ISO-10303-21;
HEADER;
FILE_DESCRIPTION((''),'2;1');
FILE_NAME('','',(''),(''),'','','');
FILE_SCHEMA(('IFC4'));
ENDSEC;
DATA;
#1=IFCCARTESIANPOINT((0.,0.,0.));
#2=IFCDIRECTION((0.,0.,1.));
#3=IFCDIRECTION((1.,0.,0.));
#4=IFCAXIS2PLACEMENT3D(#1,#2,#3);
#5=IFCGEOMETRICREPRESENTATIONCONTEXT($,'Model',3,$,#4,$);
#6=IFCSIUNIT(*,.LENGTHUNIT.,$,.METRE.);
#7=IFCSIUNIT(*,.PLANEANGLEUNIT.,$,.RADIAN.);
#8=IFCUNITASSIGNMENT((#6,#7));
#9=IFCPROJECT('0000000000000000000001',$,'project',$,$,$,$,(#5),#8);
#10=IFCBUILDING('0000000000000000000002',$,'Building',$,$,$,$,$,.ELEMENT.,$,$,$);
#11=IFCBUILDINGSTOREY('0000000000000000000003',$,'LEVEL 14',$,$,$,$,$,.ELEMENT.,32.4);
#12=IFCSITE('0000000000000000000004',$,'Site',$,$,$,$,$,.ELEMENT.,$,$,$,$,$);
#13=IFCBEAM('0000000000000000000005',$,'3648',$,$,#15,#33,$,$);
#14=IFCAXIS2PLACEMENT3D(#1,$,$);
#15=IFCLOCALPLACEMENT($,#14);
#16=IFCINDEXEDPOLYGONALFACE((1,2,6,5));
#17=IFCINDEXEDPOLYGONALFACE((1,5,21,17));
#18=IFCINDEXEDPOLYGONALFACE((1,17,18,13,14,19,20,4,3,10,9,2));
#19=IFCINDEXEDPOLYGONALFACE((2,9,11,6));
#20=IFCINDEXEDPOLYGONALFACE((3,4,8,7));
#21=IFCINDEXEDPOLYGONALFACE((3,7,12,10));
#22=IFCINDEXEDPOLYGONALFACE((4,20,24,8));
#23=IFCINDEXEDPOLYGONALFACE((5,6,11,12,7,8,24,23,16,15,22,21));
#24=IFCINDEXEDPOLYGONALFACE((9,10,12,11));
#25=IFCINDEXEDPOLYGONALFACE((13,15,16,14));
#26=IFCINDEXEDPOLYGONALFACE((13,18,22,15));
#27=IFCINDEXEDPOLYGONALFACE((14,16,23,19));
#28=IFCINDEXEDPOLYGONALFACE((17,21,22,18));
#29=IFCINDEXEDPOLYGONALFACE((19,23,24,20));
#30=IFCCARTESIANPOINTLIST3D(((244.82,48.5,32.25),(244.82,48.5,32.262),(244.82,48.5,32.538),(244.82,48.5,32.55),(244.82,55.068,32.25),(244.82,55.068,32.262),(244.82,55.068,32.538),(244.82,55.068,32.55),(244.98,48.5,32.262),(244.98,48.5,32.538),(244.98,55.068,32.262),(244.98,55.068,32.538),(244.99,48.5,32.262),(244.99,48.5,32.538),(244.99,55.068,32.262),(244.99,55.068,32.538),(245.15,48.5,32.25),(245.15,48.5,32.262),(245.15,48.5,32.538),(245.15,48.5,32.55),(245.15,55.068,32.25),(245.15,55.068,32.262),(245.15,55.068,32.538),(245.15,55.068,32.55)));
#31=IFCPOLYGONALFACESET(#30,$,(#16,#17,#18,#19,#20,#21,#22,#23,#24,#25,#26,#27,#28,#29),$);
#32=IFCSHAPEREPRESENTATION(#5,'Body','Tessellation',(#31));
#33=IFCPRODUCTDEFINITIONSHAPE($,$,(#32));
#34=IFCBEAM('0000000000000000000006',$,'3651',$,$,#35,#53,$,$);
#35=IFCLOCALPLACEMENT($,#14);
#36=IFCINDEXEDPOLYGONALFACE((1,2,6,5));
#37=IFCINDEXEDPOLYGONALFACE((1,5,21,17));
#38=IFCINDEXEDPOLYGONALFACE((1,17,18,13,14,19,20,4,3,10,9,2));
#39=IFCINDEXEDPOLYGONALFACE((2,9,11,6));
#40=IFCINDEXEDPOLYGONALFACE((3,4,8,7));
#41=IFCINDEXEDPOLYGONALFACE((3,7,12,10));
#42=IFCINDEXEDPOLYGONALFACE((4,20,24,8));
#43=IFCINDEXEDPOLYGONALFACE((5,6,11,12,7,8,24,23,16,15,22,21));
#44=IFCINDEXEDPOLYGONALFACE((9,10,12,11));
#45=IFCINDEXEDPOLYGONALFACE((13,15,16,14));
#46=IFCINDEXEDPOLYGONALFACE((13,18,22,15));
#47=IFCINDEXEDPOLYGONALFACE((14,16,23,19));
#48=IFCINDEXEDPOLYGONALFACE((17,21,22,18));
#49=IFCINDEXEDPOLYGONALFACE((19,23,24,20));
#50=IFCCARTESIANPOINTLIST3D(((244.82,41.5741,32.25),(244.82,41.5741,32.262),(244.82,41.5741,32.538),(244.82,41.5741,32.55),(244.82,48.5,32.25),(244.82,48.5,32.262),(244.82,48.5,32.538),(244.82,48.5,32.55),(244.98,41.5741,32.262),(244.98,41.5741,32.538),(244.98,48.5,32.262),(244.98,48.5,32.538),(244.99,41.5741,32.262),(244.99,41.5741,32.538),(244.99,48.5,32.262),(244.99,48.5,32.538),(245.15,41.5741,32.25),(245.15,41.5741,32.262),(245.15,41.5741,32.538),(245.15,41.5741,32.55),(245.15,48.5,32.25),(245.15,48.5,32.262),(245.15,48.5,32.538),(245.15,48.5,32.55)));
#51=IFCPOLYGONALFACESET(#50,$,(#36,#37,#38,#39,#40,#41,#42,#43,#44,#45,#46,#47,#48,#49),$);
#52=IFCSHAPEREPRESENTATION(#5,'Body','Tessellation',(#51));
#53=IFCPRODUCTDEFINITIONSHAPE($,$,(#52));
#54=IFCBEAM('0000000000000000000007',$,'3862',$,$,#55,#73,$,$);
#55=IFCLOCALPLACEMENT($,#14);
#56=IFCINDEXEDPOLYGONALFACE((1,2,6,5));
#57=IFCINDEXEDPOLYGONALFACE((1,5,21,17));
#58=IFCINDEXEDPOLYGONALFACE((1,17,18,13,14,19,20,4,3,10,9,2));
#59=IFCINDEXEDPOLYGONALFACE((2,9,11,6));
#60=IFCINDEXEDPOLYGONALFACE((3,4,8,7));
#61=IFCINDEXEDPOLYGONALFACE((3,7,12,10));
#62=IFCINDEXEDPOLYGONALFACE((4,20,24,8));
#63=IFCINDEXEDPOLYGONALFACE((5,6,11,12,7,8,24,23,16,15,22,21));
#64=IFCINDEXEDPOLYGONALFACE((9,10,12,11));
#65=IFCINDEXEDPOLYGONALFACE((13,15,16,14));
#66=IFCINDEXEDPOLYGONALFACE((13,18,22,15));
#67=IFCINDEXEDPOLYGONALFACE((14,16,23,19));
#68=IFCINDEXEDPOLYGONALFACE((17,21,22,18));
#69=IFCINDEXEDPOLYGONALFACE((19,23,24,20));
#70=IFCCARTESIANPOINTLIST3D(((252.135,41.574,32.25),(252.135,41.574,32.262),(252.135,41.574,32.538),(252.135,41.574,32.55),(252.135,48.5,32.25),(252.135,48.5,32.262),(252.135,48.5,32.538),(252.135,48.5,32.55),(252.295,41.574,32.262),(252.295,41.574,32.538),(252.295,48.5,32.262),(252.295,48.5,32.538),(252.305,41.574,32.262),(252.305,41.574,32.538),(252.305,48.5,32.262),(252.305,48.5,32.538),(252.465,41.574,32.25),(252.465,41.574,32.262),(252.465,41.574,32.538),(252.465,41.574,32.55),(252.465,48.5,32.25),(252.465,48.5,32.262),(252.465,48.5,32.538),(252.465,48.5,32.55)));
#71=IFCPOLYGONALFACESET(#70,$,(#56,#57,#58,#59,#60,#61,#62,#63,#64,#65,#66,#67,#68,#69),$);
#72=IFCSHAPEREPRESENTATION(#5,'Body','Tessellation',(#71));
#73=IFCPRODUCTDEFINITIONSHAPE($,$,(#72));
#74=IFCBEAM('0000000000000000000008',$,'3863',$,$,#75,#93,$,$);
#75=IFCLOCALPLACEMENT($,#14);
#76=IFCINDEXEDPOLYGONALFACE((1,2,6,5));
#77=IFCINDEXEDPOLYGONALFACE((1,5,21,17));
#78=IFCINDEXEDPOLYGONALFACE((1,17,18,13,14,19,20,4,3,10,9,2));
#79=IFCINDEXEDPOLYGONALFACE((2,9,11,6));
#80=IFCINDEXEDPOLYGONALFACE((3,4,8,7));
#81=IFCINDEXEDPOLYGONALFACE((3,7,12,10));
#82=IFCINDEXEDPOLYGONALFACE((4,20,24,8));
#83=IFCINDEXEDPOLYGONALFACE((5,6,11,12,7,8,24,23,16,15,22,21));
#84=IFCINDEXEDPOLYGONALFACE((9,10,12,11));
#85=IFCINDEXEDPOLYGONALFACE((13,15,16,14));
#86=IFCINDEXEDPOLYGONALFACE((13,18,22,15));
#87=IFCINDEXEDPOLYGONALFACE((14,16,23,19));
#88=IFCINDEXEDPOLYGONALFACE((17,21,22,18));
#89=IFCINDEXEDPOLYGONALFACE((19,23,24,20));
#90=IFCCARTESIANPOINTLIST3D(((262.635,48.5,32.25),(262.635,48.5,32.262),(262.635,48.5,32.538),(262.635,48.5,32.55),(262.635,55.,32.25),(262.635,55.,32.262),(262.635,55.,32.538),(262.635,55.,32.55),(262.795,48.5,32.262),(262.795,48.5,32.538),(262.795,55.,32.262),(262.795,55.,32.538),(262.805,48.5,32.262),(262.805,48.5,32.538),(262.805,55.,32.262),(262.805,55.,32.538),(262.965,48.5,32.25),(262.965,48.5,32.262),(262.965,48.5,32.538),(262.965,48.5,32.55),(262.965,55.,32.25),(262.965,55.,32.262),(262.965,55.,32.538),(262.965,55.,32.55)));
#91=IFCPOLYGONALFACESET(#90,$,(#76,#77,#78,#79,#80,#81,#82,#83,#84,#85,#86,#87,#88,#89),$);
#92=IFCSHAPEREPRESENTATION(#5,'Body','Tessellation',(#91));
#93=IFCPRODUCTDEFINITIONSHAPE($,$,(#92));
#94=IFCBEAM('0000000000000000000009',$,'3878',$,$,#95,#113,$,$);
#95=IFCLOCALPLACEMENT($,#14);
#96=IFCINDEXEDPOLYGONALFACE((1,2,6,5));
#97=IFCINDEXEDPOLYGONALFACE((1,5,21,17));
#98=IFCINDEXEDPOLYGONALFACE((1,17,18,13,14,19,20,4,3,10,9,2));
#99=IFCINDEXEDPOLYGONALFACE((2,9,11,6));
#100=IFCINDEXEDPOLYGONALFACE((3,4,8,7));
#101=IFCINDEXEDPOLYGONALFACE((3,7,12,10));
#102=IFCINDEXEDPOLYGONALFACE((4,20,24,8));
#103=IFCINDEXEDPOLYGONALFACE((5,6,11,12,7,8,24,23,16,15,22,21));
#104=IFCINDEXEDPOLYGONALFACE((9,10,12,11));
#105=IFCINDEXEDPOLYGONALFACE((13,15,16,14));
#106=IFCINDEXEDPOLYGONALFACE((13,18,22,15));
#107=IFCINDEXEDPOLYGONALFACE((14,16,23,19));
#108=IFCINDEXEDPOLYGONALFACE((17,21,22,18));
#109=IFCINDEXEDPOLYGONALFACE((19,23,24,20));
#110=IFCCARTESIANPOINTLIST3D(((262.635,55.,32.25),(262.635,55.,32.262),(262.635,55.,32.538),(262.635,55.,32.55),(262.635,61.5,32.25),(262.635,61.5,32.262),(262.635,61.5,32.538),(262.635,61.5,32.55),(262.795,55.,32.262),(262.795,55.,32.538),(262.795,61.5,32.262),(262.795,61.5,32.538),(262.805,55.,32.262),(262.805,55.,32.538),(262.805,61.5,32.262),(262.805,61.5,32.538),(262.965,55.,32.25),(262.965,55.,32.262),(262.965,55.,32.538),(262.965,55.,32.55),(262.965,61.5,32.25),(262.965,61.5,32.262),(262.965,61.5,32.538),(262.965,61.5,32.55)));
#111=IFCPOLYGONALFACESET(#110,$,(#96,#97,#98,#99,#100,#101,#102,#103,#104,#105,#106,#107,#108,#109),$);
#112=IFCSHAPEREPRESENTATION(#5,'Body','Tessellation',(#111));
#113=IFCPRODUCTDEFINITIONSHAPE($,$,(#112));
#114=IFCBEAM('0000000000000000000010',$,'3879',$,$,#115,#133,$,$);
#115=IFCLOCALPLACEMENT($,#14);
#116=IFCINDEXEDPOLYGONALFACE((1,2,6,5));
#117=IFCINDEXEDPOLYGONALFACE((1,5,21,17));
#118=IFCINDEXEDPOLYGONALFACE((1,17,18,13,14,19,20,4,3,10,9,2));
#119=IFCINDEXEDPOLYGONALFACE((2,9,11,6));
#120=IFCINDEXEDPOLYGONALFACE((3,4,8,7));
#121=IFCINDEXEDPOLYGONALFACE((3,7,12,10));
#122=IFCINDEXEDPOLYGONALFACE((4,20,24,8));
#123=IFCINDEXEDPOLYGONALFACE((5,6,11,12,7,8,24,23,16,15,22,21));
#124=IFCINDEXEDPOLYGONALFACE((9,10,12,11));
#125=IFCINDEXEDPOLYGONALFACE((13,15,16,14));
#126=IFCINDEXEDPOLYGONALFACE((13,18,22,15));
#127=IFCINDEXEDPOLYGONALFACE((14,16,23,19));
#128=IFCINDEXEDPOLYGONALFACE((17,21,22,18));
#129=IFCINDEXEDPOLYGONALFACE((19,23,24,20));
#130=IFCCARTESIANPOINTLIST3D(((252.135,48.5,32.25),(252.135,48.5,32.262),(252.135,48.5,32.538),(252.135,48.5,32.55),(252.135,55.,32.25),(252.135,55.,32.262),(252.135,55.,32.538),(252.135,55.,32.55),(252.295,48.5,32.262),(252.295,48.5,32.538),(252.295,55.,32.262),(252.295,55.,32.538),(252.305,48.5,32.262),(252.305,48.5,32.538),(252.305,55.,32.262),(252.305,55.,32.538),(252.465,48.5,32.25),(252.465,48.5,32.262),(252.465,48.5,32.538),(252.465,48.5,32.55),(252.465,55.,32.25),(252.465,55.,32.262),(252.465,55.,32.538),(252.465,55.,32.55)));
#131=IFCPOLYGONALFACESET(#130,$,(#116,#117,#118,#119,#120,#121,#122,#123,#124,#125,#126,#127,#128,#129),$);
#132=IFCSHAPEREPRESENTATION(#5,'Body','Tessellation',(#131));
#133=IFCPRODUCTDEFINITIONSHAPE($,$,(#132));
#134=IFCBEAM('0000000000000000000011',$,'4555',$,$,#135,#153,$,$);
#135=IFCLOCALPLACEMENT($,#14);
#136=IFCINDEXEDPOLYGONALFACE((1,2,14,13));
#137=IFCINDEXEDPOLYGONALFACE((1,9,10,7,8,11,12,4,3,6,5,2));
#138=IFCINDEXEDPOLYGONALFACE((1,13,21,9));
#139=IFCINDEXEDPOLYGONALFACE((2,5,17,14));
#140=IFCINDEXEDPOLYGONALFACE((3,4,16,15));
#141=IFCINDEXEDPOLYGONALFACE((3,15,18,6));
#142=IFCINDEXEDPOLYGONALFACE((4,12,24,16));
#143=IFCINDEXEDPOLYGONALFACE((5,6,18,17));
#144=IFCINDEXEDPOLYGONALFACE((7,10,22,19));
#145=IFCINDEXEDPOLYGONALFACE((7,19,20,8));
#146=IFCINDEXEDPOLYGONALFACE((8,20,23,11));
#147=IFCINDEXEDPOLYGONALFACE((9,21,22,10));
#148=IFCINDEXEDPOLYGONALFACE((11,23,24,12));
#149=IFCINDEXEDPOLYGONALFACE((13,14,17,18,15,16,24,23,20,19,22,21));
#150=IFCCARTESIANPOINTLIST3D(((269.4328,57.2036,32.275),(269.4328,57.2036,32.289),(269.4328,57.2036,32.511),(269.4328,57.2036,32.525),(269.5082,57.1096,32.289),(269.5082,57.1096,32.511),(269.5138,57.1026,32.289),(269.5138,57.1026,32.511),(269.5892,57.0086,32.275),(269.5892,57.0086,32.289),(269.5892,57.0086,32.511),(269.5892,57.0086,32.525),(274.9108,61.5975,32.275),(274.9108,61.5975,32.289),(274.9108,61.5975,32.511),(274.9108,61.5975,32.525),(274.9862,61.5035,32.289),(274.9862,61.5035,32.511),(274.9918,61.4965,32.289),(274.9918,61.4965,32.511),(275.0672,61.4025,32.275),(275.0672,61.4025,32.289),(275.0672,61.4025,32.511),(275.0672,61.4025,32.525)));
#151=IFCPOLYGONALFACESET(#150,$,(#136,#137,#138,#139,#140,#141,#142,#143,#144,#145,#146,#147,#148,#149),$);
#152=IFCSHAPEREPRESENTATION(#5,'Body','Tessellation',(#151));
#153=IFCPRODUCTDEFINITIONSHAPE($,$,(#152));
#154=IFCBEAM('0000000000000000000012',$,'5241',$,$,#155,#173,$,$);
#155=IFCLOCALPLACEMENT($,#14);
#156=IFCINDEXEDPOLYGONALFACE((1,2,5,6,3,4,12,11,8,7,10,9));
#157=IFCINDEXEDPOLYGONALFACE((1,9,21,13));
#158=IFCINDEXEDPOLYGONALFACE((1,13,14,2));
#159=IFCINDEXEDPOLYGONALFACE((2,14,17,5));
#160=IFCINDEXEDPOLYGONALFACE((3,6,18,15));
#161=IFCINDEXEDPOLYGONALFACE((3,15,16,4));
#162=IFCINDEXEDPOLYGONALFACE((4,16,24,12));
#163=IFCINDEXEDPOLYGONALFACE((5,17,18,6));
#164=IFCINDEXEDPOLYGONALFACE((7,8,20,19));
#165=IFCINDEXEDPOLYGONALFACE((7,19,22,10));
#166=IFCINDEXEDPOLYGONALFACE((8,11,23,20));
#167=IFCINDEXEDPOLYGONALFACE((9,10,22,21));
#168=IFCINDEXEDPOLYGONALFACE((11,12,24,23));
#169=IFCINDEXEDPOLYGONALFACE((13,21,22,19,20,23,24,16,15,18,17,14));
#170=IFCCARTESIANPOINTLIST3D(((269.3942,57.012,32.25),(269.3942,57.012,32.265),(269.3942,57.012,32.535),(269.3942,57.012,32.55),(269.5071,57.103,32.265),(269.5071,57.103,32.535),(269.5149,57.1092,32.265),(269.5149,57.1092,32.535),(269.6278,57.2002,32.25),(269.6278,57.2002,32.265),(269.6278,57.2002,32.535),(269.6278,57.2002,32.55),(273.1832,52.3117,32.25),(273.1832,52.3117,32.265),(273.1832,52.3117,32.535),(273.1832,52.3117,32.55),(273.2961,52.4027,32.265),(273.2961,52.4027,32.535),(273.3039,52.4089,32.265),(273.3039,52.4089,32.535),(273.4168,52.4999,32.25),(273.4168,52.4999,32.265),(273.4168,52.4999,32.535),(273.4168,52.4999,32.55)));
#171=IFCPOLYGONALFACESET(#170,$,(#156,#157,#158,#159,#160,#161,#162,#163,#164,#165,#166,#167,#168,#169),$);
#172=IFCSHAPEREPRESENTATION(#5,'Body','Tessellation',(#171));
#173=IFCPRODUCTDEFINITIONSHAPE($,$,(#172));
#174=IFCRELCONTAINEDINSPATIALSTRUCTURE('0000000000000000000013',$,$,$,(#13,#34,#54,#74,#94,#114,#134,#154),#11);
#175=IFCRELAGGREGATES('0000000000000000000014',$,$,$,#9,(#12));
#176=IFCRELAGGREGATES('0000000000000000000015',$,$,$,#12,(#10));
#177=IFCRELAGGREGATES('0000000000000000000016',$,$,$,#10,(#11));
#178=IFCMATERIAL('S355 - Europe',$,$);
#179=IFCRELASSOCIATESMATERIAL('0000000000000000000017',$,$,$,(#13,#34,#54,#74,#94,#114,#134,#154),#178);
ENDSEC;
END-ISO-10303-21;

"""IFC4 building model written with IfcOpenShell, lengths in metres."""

from ifc_helpers import new_model, si_unit, frame, origin_with_axes, origin_2d_with_axis, place, context, project, spatial, i_section, extrude, material, material_profile, profile_set, profile_usage, element, save


model = new_model("IFC4")

# Units and contexts
model_context = context("Model", 3, world=origin_with_axes())
ifc_project = project(units=[si_unit("LENGTHUNIT", "METRE"), si_unit("PLANEANGLEUNIT", "RADIAN")], contexts=[model_context])

# Site, building, storey
site = spatial("IfcSite", under=ifc_project, Name="Site", CompositionType="ELEMENT")
building = spatial("IfcBuilding", under=site, Name="Building", CompositionType="ELEMENT")
storey = spatial("IfcBuildingStorey", under=building, Name="LEVEL 14", CompositionType="ELEMENT", Elevation=32.4)

# Shared definitions
ifc_material = material(Name="S355 - Europe")

# Beams
ifc_material_profile_1 = material_profile(ifc_material, i_section(OverallWidth=0.33, OverallDepth=0.3, WebThickness=0.01, FlangeThickness=0.012, at=origin_2d_with_axis()))
ifc_profile_set_1 = profile_set([ifc_material_profile_1])
ifc_profile_usage_1 = profile_usage(ifc_profile_set_1, cardinal=10)
beam_1_placement = place(None, frame((244.985, 55.068, 32.4), z_axis=(0.0, -1.0, 0.0), x_axis=(1.0, 0.0, 0.0)))
element("IfcBeam", 1, at=beam_1_placement, inside=storey, material=ifc_profile_usage_1, Name="3648", context=model_context, shape_type="SweptSolid", body=[
    extrude(i_section(OverallWidth=0.33, OverallDepth=0.3, WebThickness=0.01, FlangeThickness=0.012, at=origin_2d_with_axis()), origin_with_axes(), (0.0, 0.0, 1.0), 6.568),
])
ifc_material_profile_2 = material_profile(ifc_material, i_section(OverallWidth=0.33, OverallDepth=0.3, WebThickness=0.01, FlangeThickness=0.012, at=origin_2d_with_axis()))
ifc_profile_set_2 = profile_set([ifc_material_profile_2])
ifc_profile_usage_2 = profile_usage(ifc_profile_set_2, cardinal=10)
beam_2_placement = place(None, frame((244.985, 48.5, 32.4), z_axis=(0.0, -1.0, 0.0), x_axis=(1.0, 0.0, 0.0)))
element("IfcBeam", 2, at=beam_2_placement, inside=storey, material=ifc_profile_usage_2, Name="3651", context=model_context, shape_type="SweptSolid", body=[
    extrude(i_section(OverallWidth=0.33, OverallDepth=0.3, WebThickness=0.01, FlangeThickness=0.012, at=origin_2d_with_axis()), origin_with_axes(), (0.0, 0.0, 1.0), 6.9259),
])
ifc_material_profile_3 = material_profile(ifc_material, i_section(OverallWidth=0.33, OverallDepth=0.3, WebThickness=0.01, FlangeThickness=0.012, at=origin_2d_with_axis()))
ifc_profile_set_3 = profile_set([ifc_material_profile_3])
ifc_profile_usage_3 = profile_usage(ifc_profile_set_3, cardinal=10)
beam_3_placement = place(None, frame((252.3, 48.5, 32.4), z_axis=(0.0, -1.0, 0.0), x_axis=(1.0, 0.0, 0.0)))
element("IfcBeam", 3, at=beam_3_placement, inside=storey, material=ifc_profile_usage_3, Name="3862", context=model_context, shape_type="SweptSolid", body=[
    extrude(i_section(OverallWidth=0.33, OverallDepth=0.3, WebThickness=0.01, FlangeThickness=0.012, at=origin_2d_with_axis()), origin_with_axes(), (0.0, 0.0, 1.0), 6.926),
])
ifc_material_profile_4 = material_profile(ifc_material, i_section(OverallWidth=0.33, OverallDepth=0.3, WebThickness=0.01, FlangeThickness=0.012, at=origin_2d_with_axis()))
ifc_profile_set_4 = profile_set([ifc_material_profile_4])
ifc_profile_usage_4 = profile_usage(ifc_profile_set_4, cardinal=10)
beam_4_placement = place(None, frame((262.8, 48.5, 32.4), z_axis=(0.0, 1.0, 0.0), x_axis=(-1.0, 0.0, 0.0)))
element("IfcBeam", 4, at=beam_4_placement, inside=storey, material=ifc_profile_usage_4, Name="3863", context=model_context, shape_type="SweptSolid", body=[
    extrude(i_section(OverallWidth=0.33, OverallDepth=0.3, WebThickness=0.01, FlangeThickness=0.012, at=origin_2d_with_axis()), origin_with_axes(), (0.0, 0.0, 1.0), 6.5),
])
ifc_material_profile_5 = material_profile(ifc_material, i_section(OverallWidth=0.33, OverallDepth=0.3, WebThickness=0.01, FlangeThickness=0.012, at=origin_2d_with_axis()))
ifc_profile_set_5 = profile_set([ifc_material_profile_5])
ifc_profile_usage_5 = profile_usage(ifc_profile_set_5, cardinal=10)
beam_5_placement = place(None, frame((262.8, 55.0, 32.4), z_axis=(0.0, 1.0, 0.0), x_axis=(-1.0, 0.0, 0.0)))
element("IfcBeam", 5, at=beam_5_placement, inside=storey, material=ifc_profile_usage_5, Name="3878", context=model_context, shape_type="SweptSolid", body=[
    extrude(i_section(OverallWidth=0.33, OverallDepth=0.3, WebThickness=0.01, FlangeThickness=0.012, at=origin_2d_with_axis()), origin_with_axes(), (0.0, 0.0, 1.0), 6.5),
])
ifc_material_profile_6 = material_profile(ifc_material, i_section(OverallWidth=0.33, OverallDepth=0.3, WebThickness=0.01, FlangeThickness=0.012, at=origin_2d_with_axis()))
ifc_profile_set_6 = profile_set([ifc_material_profile_6])
ifc_profile_usage_6 = profile_usage(ifc_profile_set_6, cardinal=10)
beam_6_placement = place(None, frame((252.3, 55.0, 32.4), z_axis=(0.0, -1.0, 0.0), x_axis=(1.0, 0.0, 0.0)))
element("IfcBeam", 6, at=beam_6_placement, inside=storey, material=ifc_profile_usage_6, Name="3879", context=model_context, shape_type="SweptSolid", body=[
    extrude(i_section(OverallWidth=0.33, OverallDepth=0.3, WebThickness=0.01, FlangeThickness=0.012, at=origin_2d_with_axis()), origin_with_axes(), (0.0, 0.0, 1.0), 6.5),
])
ifc_material_profile_7 = material_profile(ifc_material, i_section(OverallWidth=0.25, OverallDepth=0.25, WebThickness=0.009, FlangeThickness=0.014, at=origin_2d_with_axis()))
ifc_profile_set_7 = profile_set([ifc_material_profile_7])
ifc_profile_usage_7 = profile_usage(ifc_profile_set_7, cardinal=10)
beam_7_placement = place(None, frame((269.511, 57.1061, 32.4), z_axis=(0.780069, 0.625693, 0.0), x_axis=(-0.626214, 0.779651, 0.0)))
element("IfcBeam", 7, at=beam_7_placement, inside=storey, material=ifc_profile_usage_7, Name="4555", context=model_context, shape_type="SweptSolid", body=[
    extrude(i_section(OverallWidth=0.25, OverallDepth=0.25, WebThickness=0.009, FlangeThickness=0.014, at=origin_2d_with_axis()), origin_with_axes(), (0.0, 0.0, 1.0), 7.0225),
])
ifc_material_profile_8 = material_profile(ifc_material, i_section(OverallWidth=0.3, OverallDepth=0.3, WebThickness=0.01, FlangeThickness=0.015, at=origin_2d_with_axis()))
ifc_profile_set_8 = profile_set([ifc_material_profile_8])
ifc_profile_usage_8 = profile_usage(ifc_profile_set_8, cardinal=10)
beam_8_placement = place(None, frame((269.511, 57.1061, 32.4), z_axis=(0.627595, -0.77854, 0.0), x_axis=(0.77868, 0.627421, 0.0)))
element("IfcBeam", 8, at=beam_8_placement, inside=storey, material=ifc_profile_usage_8, Name="5241", context=model_context, shape_type="SweptSolid", body=[
    extrude(i_section(OverallWidth=0.3, OverallDepth=0.3, WebThickness=0.01, FlangeThickness=0.015, at=origin_2d_with_axis()), origin_with_axes(), (0.0, 0.0, 1.0), 6.0373),
])

save(model, "model.ifc")
